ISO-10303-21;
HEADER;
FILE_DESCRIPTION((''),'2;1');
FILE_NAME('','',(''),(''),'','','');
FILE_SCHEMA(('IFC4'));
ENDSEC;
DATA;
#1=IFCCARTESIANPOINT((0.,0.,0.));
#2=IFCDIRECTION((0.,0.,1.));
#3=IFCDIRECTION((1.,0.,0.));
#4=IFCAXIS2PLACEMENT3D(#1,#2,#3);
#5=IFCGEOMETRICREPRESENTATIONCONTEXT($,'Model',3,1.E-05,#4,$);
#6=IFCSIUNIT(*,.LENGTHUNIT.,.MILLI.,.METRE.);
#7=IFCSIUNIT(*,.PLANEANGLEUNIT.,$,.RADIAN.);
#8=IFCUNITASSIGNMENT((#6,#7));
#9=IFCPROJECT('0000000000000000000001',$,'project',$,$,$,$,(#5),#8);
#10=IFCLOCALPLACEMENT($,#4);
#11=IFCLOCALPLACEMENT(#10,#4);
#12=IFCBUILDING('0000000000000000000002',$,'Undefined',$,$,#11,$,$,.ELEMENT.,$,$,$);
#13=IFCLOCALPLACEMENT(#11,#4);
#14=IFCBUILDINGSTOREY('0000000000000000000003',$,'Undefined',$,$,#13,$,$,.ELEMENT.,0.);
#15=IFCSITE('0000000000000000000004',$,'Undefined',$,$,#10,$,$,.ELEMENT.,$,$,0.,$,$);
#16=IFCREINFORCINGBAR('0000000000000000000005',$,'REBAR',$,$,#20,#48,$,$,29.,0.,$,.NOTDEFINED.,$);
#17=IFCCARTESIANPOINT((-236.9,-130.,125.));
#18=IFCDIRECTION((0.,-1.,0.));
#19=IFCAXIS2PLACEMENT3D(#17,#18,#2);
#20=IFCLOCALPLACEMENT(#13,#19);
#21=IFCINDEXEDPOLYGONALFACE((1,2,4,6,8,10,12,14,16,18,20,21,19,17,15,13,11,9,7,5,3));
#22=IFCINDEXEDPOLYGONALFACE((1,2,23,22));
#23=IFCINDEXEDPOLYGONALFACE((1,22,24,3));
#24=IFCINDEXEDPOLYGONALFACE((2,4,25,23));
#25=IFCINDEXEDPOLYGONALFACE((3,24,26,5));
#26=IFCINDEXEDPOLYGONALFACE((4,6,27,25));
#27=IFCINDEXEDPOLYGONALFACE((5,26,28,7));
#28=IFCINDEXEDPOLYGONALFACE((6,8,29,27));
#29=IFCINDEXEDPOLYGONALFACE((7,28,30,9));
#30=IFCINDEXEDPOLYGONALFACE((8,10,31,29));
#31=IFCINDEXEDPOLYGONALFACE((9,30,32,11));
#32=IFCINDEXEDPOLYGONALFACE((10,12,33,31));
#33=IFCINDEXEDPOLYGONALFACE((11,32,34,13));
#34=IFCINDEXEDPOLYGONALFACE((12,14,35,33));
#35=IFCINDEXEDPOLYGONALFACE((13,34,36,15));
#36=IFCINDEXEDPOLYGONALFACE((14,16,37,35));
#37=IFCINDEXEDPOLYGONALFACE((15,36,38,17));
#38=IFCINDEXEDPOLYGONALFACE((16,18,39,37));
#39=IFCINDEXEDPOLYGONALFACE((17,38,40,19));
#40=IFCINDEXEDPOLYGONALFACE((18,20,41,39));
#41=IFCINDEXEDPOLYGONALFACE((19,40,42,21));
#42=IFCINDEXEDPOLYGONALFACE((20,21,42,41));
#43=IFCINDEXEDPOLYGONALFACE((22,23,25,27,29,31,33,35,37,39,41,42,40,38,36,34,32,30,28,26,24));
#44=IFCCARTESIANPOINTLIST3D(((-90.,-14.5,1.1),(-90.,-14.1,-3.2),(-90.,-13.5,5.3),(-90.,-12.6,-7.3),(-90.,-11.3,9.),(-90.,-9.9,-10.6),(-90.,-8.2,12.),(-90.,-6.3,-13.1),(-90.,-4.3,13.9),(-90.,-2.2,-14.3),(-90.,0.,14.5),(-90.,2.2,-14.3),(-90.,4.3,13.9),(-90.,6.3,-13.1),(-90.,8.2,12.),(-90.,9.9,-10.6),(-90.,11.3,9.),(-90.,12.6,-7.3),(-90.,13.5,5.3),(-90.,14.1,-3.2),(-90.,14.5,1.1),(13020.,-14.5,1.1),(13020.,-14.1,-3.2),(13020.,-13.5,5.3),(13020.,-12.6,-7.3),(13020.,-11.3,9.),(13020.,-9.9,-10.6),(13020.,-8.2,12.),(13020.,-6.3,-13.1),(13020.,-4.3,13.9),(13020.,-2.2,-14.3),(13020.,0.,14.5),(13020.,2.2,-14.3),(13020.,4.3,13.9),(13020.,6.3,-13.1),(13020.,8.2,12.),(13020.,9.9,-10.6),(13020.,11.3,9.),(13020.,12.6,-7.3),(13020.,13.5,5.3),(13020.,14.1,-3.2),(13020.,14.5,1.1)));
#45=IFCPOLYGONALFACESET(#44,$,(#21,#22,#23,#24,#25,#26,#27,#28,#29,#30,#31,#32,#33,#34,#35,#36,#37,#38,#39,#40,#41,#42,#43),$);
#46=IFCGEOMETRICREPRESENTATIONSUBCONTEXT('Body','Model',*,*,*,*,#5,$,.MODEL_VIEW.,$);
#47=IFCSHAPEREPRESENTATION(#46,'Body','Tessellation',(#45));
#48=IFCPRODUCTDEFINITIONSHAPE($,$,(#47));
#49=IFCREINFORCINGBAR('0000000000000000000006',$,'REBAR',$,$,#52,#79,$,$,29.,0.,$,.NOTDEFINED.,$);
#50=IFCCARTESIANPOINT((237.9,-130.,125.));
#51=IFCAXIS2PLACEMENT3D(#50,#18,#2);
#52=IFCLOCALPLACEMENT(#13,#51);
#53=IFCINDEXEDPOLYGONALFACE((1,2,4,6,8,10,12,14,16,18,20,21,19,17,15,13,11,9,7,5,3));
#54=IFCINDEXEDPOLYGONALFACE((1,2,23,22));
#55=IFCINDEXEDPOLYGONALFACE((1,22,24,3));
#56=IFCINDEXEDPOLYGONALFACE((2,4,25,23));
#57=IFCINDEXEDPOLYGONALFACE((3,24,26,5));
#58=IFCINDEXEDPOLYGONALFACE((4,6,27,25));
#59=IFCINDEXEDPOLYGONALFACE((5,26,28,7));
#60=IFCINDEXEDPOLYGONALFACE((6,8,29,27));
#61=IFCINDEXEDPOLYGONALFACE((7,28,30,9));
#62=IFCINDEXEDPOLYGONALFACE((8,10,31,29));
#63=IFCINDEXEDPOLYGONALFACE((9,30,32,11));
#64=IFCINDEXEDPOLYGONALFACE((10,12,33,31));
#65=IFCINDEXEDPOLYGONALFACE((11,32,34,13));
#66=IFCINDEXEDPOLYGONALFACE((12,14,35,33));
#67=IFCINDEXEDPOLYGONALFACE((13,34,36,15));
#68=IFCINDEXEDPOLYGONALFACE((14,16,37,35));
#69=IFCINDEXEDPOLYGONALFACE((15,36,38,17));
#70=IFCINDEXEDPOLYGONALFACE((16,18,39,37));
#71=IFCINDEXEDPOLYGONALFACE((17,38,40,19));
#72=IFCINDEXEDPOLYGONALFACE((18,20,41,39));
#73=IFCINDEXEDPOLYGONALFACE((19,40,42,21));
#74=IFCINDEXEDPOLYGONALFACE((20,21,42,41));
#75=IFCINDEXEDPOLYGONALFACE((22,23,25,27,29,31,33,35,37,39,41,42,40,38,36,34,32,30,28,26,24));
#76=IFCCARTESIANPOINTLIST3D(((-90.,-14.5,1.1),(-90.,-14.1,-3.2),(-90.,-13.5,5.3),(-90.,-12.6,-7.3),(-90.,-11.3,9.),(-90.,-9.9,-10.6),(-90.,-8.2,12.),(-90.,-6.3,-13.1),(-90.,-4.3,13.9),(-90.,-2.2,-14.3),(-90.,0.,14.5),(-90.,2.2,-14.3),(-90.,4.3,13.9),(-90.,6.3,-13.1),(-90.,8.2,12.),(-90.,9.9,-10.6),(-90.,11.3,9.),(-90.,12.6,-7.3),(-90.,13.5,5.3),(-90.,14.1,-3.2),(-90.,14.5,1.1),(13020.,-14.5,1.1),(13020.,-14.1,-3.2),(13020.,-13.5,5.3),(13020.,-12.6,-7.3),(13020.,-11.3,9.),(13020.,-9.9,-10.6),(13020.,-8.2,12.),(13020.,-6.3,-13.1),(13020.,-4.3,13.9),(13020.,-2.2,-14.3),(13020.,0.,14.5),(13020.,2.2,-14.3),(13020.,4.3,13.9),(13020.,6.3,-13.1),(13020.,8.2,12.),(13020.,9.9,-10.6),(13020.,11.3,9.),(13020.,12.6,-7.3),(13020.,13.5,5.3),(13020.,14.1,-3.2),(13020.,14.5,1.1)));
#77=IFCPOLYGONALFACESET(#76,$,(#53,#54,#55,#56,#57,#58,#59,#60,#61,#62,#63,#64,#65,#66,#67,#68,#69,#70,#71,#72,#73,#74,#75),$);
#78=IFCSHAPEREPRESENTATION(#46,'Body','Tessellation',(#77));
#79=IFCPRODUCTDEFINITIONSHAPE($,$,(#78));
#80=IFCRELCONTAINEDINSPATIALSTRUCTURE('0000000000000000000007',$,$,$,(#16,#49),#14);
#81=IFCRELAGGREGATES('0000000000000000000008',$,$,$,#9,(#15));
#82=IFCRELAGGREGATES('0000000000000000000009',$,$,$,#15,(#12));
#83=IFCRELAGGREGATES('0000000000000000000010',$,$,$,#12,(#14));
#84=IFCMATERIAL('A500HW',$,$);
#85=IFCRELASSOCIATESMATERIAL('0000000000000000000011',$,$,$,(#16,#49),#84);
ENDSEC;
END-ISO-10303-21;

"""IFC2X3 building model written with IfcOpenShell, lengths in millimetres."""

from ifc_helpers import new_model, entity, si_unit, frame, origin_with_axes, place, context, subcontext, project, spatial, source, transform, mapped, material, element, save


model = new_model("IFC2X3")

# Units and contexts
model_context = context("Model", 3, precision=1e-05, world=origin_with_axes())
body_context = subcontext(model_context, "Body", "Model", "MODEL_VIEW")
ifc_project = project(units=[si_unit("LENGTHUNIT", "METRE", prefix="MILLI"), si_unit("PLANEANGLEUNIT", "RADIAN")], contexts=[model_context])

# Site, building, storey
site_placement = place(None, origin_with_axes())
site = spatial("IfcSite", under=ifc_project, at=site_placement, Name="Undefined", CompositionType="ELEMENT", RefElevation=0.0)
building_placement = place(site_placement, origin_with_axes())
building = spatial("IfcBuilding", under=site, at=building_placement, Name="Undefined", CompositionType="ELEMENT")
storey_placement = place(building_placement, origin_with_axes())
storey = spatial("IfcBuildingStorey", under=building, at=storey_placement, Name="Undefined", CompositionType="ELEMENT", Elevation=0.0)

# Reinforcing bars
ifc_material_1 = material(Name="A500HW")
shared_shape_1 = source(origin_with_axes(), body_context, "Body", "AdvancedSweptSolid", [
    entity("IfcSweptDiskSolid", entity("IfcTrimmedCurve", entity("IfcLine", entity("IfcCartesianPoint", [0.0, 0.0, 0.0]), entity("IfcVector", entity("IfcDirection", [1.0, 0.0, 0.0]), 1.0)), [entity("IfcParameterValue", 0.0)], [entity("IfcParameterValue", 13110.03)], True, "PARAMETER"), 14.5, None, 0.0, 13110.0),
])
reinforcing_bar_1_placement = place(storey_placement, frame((-236.9, -130.0, 125.0), z_axis=(0.0, -1.0, 0.0), x_axis=(0.0, 0.0, 1.0)))
element("IfcReinforcingBar", 1, at=reinforcing_bar_1_placement, inside=storey, material=ifc_material_1, Name="REBAR", BarRole="NOTDEFINED", CrossSectionArea=0.0, NominalDiameter=29.0, context=body_context, shape_type="MappedRepresentation", body=[
    mapped(shared_shape_1, transform((-90.0, 0.0, 0.0))),
])
shared_shape_2 = source(origin_with_axes(), body_context, "Body", "AdvancedSweptSolid", [
    entity("IfcSweptDiskSolid", entity("IfcTrimmedCurve", entity("IfcLine", entity("IfcCartesianPoint", [0.0, 0.0, 0.0]), entity("IfcVector", entity("IfcDirection", [1.0, 0.0, 0.0]), 1.0)), [entity("IfcParameterValue", 0.0)], [entity("IfcParameterValue", 13110.03)], True, "PARAMETER"), 14.5, None, 0.0, 13110.0),
])
reinforcing_bar_2_placement = place(storey_placement, frame((237.9, -130.0, 125.0), z_axis=(0.0, -1.0, 0.0), x_axis=(0.0, 0.0, 1.0)))
element("IfcReinforcingBar", 2, at=reinforcing_bar_2_placement, inside=storey, material=ifc_material_1, Name="REBAR", BarRole="NOTDEFINED", CrossSectionArea=0.0, NominalDiameter=29.0, context=body_context, shape_type="MappedRepresentation", body=[
    mapped(shared_shape_2, transform((-90.0, 0.0, 0.0))),
])

save(model, "model.ifc")
